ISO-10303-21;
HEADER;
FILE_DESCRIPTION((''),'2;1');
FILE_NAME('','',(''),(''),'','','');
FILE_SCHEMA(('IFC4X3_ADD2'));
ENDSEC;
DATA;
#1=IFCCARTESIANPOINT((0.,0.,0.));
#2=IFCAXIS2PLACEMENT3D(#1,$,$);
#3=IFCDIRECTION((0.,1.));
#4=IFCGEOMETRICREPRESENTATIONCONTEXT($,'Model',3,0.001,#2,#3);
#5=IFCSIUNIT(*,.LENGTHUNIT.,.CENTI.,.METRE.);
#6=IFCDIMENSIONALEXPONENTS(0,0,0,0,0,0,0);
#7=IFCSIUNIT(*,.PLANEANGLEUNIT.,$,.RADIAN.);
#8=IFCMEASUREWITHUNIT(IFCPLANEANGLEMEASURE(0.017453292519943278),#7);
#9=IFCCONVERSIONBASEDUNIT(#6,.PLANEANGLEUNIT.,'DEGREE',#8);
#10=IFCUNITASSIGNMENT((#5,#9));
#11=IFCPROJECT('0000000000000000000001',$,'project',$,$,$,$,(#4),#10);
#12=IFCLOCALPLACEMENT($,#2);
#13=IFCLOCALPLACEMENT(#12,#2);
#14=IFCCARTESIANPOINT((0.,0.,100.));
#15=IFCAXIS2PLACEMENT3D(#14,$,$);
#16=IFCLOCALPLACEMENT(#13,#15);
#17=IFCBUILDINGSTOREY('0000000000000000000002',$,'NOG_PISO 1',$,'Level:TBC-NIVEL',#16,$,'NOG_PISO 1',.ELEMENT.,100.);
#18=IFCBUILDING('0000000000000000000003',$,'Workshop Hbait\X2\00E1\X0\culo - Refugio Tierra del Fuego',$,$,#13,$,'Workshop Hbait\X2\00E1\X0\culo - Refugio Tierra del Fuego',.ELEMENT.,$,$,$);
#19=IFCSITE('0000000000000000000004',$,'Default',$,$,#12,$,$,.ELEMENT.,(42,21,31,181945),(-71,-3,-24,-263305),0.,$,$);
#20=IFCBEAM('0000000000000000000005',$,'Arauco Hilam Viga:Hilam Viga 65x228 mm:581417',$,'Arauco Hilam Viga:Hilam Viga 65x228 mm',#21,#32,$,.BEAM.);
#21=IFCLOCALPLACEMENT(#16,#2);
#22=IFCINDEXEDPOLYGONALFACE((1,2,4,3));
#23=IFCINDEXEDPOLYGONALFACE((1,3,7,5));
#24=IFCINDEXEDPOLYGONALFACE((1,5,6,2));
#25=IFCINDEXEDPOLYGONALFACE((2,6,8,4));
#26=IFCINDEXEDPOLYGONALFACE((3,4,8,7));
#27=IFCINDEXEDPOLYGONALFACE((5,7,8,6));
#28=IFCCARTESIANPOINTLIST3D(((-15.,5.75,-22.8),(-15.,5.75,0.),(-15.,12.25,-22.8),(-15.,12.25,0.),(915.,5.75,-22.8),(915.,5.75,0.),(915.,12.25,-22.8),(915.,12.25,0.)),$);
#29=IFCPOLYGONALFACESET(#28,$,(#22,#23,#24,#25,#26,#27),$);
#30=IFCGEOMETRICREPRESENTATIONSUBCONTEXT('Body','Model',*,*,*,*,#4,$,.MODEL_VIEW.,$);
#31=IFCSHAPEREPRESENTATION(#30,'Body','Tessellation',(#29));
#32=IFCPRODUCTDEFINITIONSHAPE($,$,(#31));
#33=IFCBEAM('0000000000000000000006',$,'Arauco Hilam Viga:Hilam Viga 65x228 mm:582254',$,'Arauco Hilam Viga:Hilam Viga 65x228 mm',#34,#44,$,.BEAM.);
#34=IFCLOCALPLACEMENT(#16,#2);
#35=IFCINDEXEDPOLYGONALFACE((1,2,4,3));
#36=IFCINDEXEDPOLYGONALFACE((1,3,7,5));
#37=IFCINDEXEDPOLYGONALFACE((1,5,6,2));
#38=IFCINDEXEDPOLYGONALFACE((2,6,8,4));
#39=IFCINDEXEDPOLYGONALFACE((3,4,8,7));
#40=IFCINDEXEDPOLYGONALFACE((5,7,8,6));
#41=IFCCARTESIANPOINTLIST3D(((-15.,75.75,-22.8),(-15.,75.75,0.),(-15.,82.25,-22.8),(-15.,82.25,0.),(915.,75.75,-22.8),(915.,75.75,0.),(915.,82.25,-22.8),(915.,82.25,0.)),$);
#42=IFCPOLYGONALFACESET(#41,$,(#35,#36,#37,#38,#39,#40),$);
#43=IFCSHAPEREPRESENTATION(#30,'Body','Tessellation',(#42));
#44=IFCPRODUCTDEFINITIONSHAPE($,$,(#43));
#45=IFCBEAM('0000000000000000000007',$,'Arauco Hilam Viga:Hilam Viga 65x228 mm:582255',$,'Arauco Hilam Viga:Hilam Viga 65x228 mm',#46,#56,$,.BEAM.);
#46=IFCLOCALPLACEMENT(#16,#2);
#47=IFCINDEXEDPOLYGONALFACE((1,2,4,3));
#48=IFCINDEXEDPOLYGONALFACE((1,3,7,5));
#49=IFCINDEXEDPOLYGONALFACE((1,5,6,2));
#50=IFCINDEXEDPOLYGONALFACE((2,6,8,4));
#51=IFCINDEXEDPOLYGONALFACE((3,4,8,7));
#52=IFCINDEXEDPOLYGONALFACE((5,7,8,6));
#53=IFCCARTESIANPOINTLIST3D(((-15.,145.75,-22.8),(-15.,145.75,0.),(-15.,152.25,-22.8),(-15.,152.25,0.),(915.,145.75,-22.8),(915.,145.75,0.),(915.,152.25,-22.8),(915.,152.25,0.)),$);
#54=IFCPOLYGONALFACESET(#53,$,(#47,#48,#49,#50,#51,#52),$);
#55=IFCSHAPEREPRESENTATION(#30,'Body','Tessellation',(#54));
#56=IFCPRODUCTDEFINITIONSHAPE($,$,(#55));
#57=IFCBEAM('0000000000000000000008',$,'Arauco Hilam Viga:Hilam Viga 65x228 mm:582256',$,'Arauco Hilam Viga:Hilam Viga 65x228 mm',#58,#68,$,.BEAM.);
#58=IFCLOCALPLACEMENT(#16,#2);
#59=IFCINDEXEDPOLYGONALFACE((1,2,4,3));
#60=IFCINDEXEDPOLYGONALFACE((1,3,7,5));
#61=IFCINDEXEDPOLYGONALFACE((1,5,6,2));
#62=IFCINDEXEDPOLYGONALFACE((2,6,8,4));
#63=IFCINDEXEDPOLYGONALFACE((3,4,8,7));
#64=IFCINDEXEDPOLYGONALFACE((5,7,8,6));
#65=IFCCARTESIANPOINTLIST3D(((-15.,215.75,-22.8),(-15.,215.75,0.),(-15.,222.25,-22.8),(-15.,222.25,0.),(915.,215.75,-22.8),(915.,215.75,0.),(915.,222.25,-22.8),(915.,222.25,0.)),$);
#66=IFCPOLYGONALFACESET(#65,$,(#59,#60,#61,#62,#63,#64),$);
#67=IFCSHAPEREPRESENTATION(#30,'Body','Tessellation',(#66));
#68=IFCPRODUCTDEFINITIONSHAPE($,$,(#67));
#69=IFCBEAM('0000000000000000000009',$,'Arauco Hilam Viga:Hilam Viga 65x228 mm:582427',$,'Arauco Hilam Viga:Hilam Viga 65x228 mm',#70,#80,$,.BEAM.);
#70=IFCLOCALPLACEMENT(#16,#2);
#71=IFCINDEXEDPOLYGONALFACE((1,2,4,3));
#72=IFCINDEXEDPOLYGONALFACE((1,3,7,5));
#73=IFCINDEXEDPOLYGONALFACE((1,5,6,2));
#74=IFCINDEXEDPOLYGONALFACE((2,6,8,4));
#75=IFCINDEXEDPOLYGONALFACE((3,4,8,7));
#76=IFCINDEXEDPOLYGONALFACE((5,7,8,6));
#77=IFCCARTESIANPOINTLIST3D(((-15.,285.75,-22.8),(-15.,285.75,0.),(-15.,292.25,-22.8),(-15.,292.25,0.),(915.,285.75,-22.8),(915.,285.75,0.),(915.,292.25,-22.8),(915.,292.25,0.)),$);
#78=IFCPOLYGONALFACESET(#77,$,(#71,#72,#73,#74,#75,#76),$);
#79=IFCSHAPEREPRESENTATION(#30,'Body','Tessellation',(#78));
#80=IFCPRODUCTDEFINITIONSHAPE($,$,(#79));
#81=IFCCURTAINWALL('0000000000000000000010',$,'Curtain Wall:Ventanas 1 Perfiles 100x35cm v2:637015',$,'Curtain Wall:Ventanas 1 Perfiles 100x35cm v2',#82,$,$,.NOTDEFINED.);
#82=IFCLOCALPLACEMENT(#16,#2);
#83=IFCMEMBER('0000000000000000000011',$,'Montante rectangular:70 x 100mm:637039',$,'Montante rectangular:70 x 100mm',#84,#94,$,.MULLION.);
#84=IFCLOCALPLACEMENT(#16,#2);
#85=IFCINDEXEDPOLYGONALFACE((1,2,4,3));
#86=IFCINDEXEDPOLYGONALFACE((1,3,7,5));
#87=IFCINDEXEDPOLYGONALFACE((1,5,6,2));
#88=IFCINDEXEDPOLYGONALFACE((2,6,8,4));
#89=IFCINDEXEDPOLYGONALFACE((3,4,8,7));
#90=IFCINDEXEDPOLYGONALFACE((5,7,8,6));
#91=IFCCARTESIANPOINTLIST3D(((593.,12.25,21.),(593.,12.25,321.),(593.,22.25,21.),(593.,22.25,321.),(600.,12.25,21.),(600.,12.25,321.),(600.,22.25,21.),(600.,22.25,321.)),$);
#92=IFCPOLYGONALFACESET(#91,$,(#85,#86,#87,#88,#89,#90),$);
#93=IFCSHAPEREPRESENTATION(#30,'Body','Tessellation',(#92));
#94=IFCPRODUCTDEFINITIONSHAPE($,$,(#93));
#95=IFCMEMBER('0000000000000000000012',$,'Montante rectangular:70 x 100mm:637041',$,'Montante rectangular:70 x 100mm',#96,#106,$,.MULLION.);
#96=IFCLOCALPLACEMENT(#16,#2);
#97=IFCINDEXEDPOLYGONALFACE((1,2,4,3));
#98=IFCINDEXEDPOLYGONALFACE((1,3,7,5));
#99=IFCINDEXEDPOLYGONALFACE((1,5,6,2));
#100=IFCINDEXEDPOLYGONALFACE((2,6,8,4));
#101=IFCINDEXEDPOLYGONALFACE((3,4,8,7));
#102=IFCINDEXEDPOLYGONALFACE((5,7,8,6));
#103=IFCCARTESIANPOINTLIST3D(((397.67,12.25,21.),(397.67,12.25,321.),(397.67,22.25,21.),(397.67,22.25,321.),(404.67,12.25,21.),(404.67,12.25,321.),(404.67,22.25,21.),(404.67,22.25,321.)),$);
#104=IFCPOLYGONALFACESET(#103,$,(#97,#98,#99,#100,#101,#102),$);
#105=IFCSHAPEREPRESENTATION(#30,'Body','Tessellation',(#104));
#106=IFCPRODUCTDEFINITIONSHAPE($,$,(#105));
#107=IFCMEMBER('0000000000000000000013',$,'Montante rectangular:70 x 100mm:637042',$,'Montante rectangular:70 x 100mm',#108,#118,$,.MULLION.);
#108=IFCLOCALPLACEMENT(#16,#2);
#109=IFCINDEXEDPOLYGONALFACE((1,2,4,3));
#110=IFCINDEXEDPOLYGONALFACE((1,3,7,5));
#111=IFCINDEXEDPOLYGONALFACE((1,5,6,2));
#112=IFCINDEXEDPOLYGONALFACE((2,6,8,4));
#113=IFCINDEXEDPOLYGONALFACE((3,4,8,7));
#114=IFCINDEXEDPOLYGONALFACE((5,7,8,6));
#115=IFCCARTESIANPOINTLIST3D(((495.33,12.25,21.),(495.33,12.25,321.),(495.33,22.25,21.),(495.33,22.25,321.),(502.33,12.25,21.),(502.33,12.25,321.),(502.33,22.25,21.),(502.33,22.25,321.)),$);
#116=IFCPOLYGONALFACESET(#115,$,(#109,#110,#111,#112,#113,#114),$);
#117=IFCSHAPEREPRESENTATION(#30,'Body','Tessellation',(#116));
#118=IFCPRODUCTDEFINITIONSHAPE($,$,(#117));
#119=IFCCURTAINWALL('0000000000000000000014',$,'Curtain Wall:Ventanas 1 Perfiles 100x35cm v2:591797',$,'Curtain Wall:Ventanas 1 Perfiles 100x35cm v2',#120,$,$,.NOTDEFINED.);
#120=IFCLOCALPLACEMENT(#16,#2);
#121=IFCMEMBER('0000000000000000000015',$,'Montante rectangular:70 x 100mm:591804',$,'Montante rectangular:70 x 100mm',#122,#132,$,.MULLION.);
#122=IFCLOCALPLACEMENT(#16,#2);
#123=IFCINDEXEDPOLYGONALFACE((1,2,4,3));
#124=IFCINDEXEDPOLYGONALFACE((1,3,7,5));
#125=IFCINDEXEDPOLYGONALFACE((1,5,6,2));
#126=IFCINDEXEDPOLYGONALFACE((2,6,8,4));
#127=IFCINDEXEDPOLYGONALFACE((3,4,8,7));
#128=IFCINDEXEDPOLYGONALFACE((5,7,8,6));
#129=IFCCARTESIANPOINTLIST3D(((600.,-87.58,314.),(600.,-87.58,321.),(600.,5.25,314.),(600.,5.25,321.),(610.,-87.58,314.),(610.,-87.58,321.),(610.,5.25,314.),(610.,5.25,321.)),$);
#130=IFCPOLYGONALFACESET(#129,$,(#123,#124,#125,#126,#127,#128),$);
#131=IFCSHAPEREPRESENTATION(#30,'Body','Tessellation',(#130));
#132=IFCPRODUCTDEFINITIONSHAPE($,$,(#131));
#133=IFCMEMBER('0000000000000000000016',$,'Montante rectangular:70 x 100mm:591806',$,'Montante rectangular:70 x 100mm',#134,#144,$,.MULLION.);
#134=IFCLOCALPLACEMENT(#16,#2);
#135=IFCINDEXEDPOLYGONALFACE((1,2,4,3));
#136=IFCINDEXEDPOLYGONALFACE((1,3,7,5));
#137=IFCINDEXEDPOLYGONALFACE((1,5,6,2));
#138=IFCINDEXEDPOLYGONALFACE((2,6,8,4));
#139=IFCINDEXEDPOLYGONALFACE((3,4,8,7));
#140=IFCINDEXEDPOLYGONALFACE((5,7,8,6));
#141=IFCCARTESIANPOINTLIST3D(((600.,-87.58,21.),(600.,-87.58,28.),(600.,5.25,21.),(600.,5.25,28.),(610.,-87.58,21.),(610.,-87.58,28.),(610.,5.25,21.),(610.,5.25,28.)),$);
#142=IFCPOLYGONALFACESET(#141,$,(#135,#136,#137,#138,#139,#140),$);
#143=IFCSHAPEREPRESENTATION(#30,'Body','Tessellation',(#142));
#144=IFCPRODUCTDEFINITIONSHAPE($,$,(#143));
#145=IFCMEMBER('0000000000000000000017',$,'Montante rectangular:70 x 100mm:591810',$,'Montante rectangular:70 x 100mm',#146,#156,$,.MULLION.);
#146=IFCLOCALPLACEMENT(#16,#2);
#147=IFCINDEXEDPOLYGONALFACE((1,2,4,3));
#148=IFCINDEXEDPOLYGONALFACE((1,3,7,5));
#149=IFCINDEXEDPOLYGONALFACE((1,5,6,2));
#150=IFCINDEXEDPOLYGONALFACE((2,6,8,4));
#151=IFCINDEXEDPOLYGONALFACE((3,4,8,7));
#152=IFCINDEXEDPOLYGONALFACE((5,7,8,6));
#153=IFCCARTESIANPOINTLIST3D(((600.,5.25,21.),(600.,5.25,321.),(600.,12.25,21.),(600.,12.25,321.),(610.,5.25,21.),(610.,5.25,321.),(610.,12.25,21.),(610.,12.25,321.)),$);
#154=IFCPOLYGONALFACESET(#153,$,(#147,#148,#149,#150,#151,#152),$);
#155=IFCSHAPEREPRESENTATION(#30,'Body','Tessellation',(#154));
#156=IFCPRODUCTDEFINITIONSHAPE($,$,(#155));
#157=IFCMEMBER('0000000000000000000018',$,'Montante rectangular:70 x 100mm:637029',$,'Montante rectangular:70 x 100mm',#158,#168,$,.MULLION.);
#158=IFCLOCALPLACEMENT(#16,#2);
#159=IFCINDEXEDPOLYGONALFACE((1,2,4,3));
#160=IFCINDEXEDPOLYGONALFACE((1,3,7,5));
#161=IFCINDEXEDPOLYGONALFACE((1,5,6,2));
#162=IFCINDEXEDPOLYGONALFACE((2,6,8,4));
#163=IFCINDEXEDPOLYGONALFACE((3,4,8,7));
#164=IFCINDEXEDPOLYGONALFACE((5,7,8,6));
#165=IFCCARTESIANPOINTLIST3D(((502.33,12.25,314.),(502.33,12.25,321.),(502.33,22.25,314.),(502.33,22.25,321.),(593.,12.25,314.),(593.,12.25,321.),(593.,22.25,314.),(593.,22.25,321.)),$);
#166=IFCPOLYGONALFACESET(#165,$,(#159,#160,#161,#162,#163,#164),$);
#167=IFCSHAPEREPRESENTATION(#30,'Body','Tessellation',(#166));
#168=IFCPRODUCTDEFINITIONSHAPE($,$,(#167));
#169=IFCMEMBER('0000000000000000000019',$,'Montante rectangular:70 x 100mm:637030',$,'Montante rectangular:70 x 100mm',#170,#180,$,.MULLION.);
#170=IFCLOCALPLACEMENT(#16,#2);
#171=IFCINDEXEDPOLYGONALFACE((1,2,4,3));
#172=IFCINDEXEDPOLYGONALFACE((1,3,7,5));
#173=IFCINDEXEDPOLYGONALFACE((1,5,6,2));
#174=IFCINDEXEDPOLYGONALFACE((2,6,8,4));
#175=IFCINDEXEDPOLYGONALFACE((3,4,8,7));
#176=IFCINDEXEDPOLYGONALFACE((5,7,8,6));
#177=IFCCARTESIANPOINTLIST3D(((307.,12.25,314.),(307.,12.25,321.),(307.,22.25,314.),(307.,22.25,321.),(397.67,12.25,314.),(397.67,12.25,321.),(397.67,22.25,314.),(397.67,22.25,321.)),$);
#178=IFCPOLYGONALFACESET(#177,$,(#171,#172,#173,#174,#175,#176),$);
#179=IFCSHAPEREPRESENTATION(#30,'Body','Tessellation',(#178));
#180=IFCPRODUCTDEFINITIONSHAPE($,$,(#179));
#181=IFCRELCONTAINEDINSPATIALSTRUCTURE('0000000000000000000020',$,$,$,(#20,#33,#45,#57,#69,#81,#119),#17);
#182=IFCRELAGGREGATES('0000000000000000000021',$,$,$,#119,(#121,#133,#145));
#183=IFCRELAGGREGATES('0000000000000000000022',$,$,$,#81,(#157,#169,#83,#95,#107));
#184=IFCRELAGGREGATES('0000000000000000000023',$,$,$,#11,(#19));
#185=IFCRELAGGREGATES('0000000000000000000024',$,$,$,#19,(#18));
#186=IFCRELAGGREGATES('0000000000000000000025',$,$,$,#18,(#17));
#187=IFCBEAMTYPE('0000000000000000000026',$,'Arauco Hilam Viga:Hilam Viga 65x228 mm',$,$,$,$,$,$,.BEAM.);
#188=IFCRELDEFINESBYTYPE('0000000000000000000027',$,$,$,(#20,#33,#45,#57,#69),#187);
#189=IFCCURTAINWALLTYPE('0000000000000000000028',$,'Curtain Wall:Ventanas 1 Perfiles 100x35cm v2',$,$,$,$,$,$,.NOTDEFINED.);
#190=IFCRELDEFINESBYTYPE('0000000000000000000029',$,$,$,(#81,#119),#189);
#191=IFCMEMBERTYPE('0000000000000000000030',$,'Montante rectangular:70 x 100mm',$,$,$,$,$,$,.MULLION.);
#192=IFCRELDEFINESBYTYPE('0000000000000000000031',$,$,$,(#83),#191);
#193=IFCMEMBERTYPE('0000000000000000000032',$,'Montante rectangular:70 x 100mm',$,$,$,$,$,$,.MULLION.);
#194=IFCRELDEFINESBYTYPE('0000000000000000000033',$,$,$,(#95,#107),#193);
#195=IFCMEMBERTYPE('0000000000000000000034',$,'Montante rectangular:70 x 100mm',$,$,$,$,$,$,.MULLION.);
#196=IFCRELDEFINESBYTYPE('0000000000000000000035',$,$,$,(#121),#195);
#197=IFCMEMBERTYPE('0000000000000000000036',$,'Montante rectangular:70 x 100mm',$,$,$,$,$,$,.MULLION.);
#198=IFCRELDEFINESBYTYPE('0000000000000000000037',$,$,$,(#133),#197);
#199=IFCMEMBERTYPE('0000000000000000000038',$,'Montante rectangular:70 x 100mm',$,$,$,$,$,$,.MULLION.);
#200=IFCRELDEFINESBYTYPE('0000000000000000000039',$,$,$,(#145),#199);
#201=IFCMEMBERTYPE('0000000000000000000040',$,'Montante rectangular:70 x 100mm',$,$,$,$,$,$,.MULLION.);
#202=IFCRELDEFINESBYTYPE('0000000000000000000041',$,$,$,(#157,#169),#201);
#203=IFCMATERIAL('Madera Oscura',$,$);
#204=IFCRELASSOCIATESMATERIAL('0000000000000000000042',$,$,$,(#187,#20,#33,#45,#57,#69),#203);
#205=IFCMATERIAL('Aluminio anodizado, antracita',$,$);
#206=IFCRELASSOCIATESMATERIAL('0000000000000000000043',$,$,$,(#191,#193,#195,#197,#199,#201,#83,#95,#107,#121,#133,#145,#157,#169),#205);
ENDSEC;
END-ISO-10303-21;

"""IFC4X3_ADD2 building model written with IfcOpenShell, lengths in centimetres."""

from ifc_helpers import new_model, entity, si_unit, converted_unit, direction, frame, frame_2d, origin, origin_2d_with_axis, place, context, subcontext, project, spatial, rectangle, extrude, source, transform, mapped, material, material_profile, profile_set, profile_usage, type_object, type_shapes, element, aggregate, save


model = new_model("IFC4X3_ADD2")

# Units and contexts
model_context = context("Model", 3, precision=0.001, world=origin(), true_north=direction((0.0, 1.0)))
body_context = subcontext(model_context, "Body", "Model", "MODEL_VIEW")
ifc_project = project(units=[si_unit("LENGTHUNIT", "METRE", prefix="CENTI"), converted_unit("PLANEANGLEUNIT", "DEGREE", entity("IfcPlaneAngleMeasure", 0.017453292519943278), si_unit("PLANEANGLEUNIT", "RADIAN"), dimensions=[0, 0, 0, 0, 0, 0, 0])], contexts=[model_context])

# Site, building, storey
site_placement = place(None, origin())
site = spatial("IfcSite", under=ifc_project, at=site_placement, Name="Default", CompositionType="ELEMENT", RefLatitude=(42, 21, 31, 181945), RefLongitude=(-71, -3, -24, -263305), RefElevation=0.0)
building_placement = place(site_placement, origin())
building = spatial("IfcBuilding", under=site, at=building_placement, Name="Workshop Hbaitáculo - Refugio Tierra del Fuego", LongName="Workshop Hbaitáculo - Refugio Tierra del Fuego", CompositionType="ELEMENT")
storey_placement = place(building_placement, frame((0.0, 0.0, 100.0)))
storey = spatial("IfcBuildingStorey", under=building, at=storey_placement, Name="NOG_PISO 1", ObjectType="Level:TBC-NIVEL", LongName="NOG_PISO 1", CompositionType="ELEMENT", Elevation=100.0)

# Beams
ifc_material_1 = material(Name="Madera Oscura")
ifc_material_profile_1 = material_profile(ifc_material_1, rectangle(XDim=930.0, YDim=6.5, at=origin_2d_with_axis()), Name="Hilam Viga 65x228 mm")
ifc_profile_set_1 = profile_set([ifc_material_profile_1], Name="Hilam Viga 65x228 mm")
ifc_profile_usage_1 = profile_usage(ifc_profile_set_1, cardinal=8)
beam_type_1 = type_object("IfcBeamType", Name="Arauco Hilam Viga:Hilam Viga 65x228 mm", PredefinedType="BEAM", material=ifc_profile_set_1)
shared_shape_1 = source(origin(), body_context, "Body", "SweptSolid", [
    extrude(rectangle(XDim=930.0, YDim=6.5, at=origin_2d_with_axis()), frame((15.63, 0.0, -11.4), z_axis=(0.0, 0.0, 1.0), x_axis=(-1.0, 0.0, 0.0)), (0.0, 0.0, 1.0), 22.8),
])
type_shapes(beam_type_1, [shared_shape_1])
for number, where, name in (
    (1, (434.37, 9.0, -11.4), "Arauco Hilam Viga:Hilam Viga 65x228 mm:581417"),
    (2, (434.37, 79.0, -11.4), "Arauco Hilam Viga:Hilam Viga 65x228 mm:582254"),
    (3, (434.37, 149.0, -11.4), "Arauco Hilam Viga:Hilam Viga 65x228 mm:582255"),
    (4, (434.37, 219.0, -11.4), "Arauco Hilam Viga:Hilam Viga 65x228 mm:582256"),
    (5, (434.37, 289.0, -11.4), "Arauco Hilam Viga:Hilam Viga 65x228 mm:582427"),
):
    element("IfcBeam", number, at=place(storey_placement, frame(where)), inside=storey, type_object=beam_type_1, material=ifc_profile_usage_1, Name=name, ObjectType="Arauco Hilam Viga:Hilam Viga 65x228 mm", PredefinedType="BEAM", context=body_context, shape_type="MappedRepresentation", body=[
        mapped(shared_shape_1, transform((0.0, 0.0, 0.0), scale=1.0)),
    ])

# Curtain walls, members
curtain_wall_type = type_object("IfcCurtainWallType", Name="Curtain Wall:Ventanas 1 Perfiles 100x35cm v2", PredefinedType="NOTDEFINED")
curtain_wall_1_placement = place(storey_placement, frame((0.0, 0.0, -100.0)))
curtain_wall_1 = element("IfcCurtainWall", 6, at=curtain_wall_1_placement, inside=storey, type_object=curtain_wall_type, Name="Curtain Wall:Ventanas 1 Perfiles 100x35cm v2:637015", ObjectType="Curtain Wall:Ventanas 1 Perfiles 100x35cm v2", PredefinedType="NOTDEFINED")
ifc_material_2 = material(Name="Aluminio anodizado, antracita")
ifc_material_profile_2 = material_profile(ifc_material_2, rectangle(XDim=7.0, YDim=10.0, at=origin_2d_with_axis()), Name="70 x 100mm")
ifc_profile_set_2 = profile_set([ifc_material_profile_2], Name="70 x 100mm")
ifc_profile_usage_2 = profile_usage(ifc_profile_set_2)
member_type_1 = type_object("IfcMemberType", Name="Montante rectangular:70 x 100mm", PredefinedType="MULLION", material=ifc_profile_set_2)
shared_shape_2 = source(origin(), body_context, "Body", "SweptSolid", [
    extrude(rectangle(XDim=7.0, YDim=10.0, at=origin_2d_with_axis()), frame((-3.5, 0.0, -300.0), z_axis=(0.0, 0.0, 1.0), x_axis=(-1.0, 0.0, 0.0)), (0.0, 0.0, 1.0), 300.0),
])
type_shapes(member_type_1, [shared_shape_2])
member_1_placement = place(curtain_wall_1_placement, frame((600.0, 17.25, 121.0), z_axis=(0.0, 0.0, -1.0), x_axis=(1.0, 0.0, 0.0)))
member_1 = element("IfcMember", 7, at=member_1_placement, type_object=member_type_1, material=ifc_profile_usage_2, Name="Montante rectangular:70 x 100mm:637039", ObjectType="Montante rectangular:70 x 100mm", PredefinedType="MULLION", context=body_context, shape_type="MappedRepresentation", body=[
    mapped(shared_shape_2, transform((0.0, 0.0, 0.0), scale=1.0)),
])
member_type_2 = type_object("IfcMemberType", Name="Montante rectangular:70 x 100mm", PredefinedType="MULLION", material=ifc_profile_set_2)
shared_shape_3 = source(origin(), body_context, "Body", "SweptSolid", [
    extrude(rectangle(XDim=7.0, YDim=10.0, at=frame_2d((0.0, 0.0), x_axis=(1.0, 0.0))), frame((0.0, 0.0, -300.0), z_axis=(0.0, 0.0, 1.0), x_axis=(-1.0, 0.0, 0.0)), (0.0, 0.0, 1.0), 300.0),
])
type_shapes(member_type_2, [shared_shape_3])
member_2_placement = place(curtain_wall_1_placement, frame((401.17, 17.25, 121.0), z_axis=(0.0, 0.0, -1.0), x_axis=(1.0, 0.0, 0.0)))
member_2 = element("IfcMember", 8, at=member_2_placement, type_object=member_type_2, material=ifc_profile_usage_2, Name="Montante rectangular:70 x 100mm:637041", ObjectType="Montante rectangular:70 x 100mm", PredefinedType="MULLION", context=body_context, shape_type="MappedRepresentation", body=[
    mapped(shared_shape_3, transform((0.0, 0.0, 0.0), scale=1.0)),
])
member_3_placement = place(curtain_wall_1_placement, frame((498.83, 17.25, 121.0), z_axis=(0.0, 0.0, -1.0), x_axis=(1.0, 0.0, 0.0)))
member_3 = element("IfcMember", 9, at=member_3_placement, type_object=member_type_2, material=ifc_profile_usage_2, Name="Montante rectangular:70 x 100mm:637042", ObjectType="Montante rectangular:70 x 100mm", PredefinedType="MULLION", context=body_context, shape_type="MappedRepresentation", body=[
    mapped(shared_shape_3, transform((0.0, 0.0, 0.0), scale=1.0)),
])
curtain_wall_2_placement = place(storey_placement, frame((0.0, 0.0, -100.0)))
curtain_wall_2 = element("IfcCurtainWall", 10, at=curtain_wall_2_placement, inside=storey, type_object=curtain_wall_type, Name="Curtain Wall:Ventanas 1 Perfiles 100x35cm v2:591797", ObjectType="Curtain Wall:Ventanas 1 Perfiles 100x35cm v2", PredefinedType="NOTDEFINED")
member_type_3 = type_object("IfcMemberType", Name="Montante rectangular:70 x 100mm", PredefinedType="MULLION", material=ifc_profile_set_2)
shared_shape_4 = source(origin(), body_context, "Body", "SweptSolid", [
    extrude(rectangle(XDim=7.0, YDim=10.0, at=origin_2d_with_axis()), frame((-3.5, 0.0, -92.83), z_axis=(0.0, 0.0, 1.0), x_axis=(-1.0, 0.0, 0.0)), (0.0, 0.0, 1.0), 92.83),
])
type_shapes(member_type_3, [shared_shape_4])
member_4_placement = place(curtain_wall_2_placement, frame((605.0, -87.58, 421.0), z_axis=(0.0, -1.0, 0.0), x_axis=(0.0, 0.0, 1.0)))
member_4 = element("IfcMember", 11, at=member_4_placement, type_object=member_type_3, material=ifc_profile_usage_2, Name="Montante rectangular:70 x 100mm:591804", ObjectType="Montante rectangular:70 x 100mm", PredefinedType="MULLION", context=body_context, shape_type="MappedRepresentation", body=[
    mapped(shared_shape_4, transform((0.0, 0.0, 0.0), scale=1.0)),
])
member_type_4 = type_object("IfcMemberType", Name="Montante rectangular:70 x 100mm", PredefinedType="MULLION", material=ifc_profile_set_2)
shared_shape_5 = source(origin(), body_context, "Body", "SweptSolid", [
    extrude(rectangle(XDim=7.0, YDim=10.0, at=origin_2d_with_axis()), frame((-3.5, 0.0, -92.83), z_axis=(0.0, 0.0, 1.0), x_axis=(-1.0, 0.0, 0.0)), (0.0, 0.0, 1.0), 92.83),
])
type_shapes(member_type_4, [shared_shape_5])
member_5_placement = place(curtain_wall_2_placement, frame((605.0, 5.25, 121.0), z_axis=(0.0, 1.0, 0.0), x_axis=(0.0, 0.0, -1.0)))
member_5 = element("IfcMember", 12, at=member_5_placement, type_object=member_type_4, material=ifc_profile_usage_2, Name="Montante rectangular:70 x 100mm:591806", ObjectType="Montante rectangular:70 x 100mm", PredefinedType="MULLION", context=body_context, shape_type="MappedRepresentation", body=[
    mapped(shared_shape_5, transform((0.0, 0.0, 0.0), scale=1.0)),
])
member_type_5 = type_object("IfcMemberType", Name="Montante rectangular:70 x 100mm", PredefinedType="MULLION", material=ifc_profile_set_2)
shared_shape_6 = source(origin(), body_context, "Body", "SweptSolid", [
    extrude(rectangle(XDim=7.0, YDim=10.0, at=origin_2d_with_axis()), frame((-3.5, 0.0, -300.0), z_axis=(0.0, 0.0, 1.0), x_axis=(-1.0, 0.0, 0.0)), (0.0, 0.0, 1.0), 300.0),
])
type_shapes(member_type_5, [shared_shape_6])
member_6_placement = place(curtain_wall_2_placement, frame((605.0, 12.25, 421.0), z_axis=(0.0, 0.0, 1.0), x_axis=(0.0, 1.0, 0.0)))
member_6 = element("IfcMember", 13, at=member_6_placement, type_object=member_type_5, material=ifc_profile_usage_2, Name="Montante rectangular:70 x 100mm:591810", ObjectType="Montante rectangular:70 x 100mm", PredefinedType="MULLION", context=body_context, shape_type="MappedRepresentation", body=[
    mapped(shared_shape_6, transform((0.0, 0.0, 0.0), scale=1.0)),
])

# Members
member_type_6 = type_object("IfcMemberType", Name="Montante rectangular:70 x 100mm", PredefinedType="MULLION", material=ifc_profile_set_2)
shared_shape_7 = source(origin(), body_context, "Body", "SweptSolid", [
    extrude(rectangle(XDim=7.0, YDim=10.0, at=origin_2d_with_axis()), frame((-3.5, 0.0, -90.67), z_axis=(0.0, 0.0, 1.0), x_axis=(-1.0, 0.0, 0.0)), (0.0, 0.0, 1.0), 90.67),
])
type_shapes(member_type_6, [shared_shape_7])
member_7_placement = place(curtain_wall_1_placement, frame((593.0, 17.25, 421.0), z_axis=(1.0, 0.0, 0.0), x_axis=(0.0, 0.0, 1.0)))
member_7 = element("IfcMember", 14, at=member_7_placement, type_object=member_type_6, material=ifc_profile_usage_2, Name="Montante rectangular:70 x 100mm:637029", ObjectType="Montante rectangular:70 x 100mm", PredefinedType="MULLION", context=body_context, shape_type="MappedRepresentation", body=[
    mapped(shared_shape_7, transform((0.0, 0.0, 0.0), scale=1.0)),
])
member_8_placement = place(curtain_wall_1_placement, frame((397.67, 17.25, 421.0), z_axis=(1.0, 0.0, 0.0), x_axis=(0.0, 0.0, 1.0)))
member_8 = element("IfcMember", 15, at=member_8_placement, type_object=member_type_6, material=ifc_profile_usage_2, Name="Montante rectangular:70 x 100mm:637030", ObjectType="Montante rectangular:70 x 100mm", PredefinedType="MULLION", context=body_context, shape_type="MappedRepresentation", body=[
    mapped(shared_shape_7, transform((0.0, 0.0, 0.0), scale=1.0)),
])

aggregate(curtain_wall_2, [member_4, member_5, member_6])
aggregate(curtain_wall_1, [member_7, member_8, member_1, member_2, member_3])

save(model, "model.ifc")
